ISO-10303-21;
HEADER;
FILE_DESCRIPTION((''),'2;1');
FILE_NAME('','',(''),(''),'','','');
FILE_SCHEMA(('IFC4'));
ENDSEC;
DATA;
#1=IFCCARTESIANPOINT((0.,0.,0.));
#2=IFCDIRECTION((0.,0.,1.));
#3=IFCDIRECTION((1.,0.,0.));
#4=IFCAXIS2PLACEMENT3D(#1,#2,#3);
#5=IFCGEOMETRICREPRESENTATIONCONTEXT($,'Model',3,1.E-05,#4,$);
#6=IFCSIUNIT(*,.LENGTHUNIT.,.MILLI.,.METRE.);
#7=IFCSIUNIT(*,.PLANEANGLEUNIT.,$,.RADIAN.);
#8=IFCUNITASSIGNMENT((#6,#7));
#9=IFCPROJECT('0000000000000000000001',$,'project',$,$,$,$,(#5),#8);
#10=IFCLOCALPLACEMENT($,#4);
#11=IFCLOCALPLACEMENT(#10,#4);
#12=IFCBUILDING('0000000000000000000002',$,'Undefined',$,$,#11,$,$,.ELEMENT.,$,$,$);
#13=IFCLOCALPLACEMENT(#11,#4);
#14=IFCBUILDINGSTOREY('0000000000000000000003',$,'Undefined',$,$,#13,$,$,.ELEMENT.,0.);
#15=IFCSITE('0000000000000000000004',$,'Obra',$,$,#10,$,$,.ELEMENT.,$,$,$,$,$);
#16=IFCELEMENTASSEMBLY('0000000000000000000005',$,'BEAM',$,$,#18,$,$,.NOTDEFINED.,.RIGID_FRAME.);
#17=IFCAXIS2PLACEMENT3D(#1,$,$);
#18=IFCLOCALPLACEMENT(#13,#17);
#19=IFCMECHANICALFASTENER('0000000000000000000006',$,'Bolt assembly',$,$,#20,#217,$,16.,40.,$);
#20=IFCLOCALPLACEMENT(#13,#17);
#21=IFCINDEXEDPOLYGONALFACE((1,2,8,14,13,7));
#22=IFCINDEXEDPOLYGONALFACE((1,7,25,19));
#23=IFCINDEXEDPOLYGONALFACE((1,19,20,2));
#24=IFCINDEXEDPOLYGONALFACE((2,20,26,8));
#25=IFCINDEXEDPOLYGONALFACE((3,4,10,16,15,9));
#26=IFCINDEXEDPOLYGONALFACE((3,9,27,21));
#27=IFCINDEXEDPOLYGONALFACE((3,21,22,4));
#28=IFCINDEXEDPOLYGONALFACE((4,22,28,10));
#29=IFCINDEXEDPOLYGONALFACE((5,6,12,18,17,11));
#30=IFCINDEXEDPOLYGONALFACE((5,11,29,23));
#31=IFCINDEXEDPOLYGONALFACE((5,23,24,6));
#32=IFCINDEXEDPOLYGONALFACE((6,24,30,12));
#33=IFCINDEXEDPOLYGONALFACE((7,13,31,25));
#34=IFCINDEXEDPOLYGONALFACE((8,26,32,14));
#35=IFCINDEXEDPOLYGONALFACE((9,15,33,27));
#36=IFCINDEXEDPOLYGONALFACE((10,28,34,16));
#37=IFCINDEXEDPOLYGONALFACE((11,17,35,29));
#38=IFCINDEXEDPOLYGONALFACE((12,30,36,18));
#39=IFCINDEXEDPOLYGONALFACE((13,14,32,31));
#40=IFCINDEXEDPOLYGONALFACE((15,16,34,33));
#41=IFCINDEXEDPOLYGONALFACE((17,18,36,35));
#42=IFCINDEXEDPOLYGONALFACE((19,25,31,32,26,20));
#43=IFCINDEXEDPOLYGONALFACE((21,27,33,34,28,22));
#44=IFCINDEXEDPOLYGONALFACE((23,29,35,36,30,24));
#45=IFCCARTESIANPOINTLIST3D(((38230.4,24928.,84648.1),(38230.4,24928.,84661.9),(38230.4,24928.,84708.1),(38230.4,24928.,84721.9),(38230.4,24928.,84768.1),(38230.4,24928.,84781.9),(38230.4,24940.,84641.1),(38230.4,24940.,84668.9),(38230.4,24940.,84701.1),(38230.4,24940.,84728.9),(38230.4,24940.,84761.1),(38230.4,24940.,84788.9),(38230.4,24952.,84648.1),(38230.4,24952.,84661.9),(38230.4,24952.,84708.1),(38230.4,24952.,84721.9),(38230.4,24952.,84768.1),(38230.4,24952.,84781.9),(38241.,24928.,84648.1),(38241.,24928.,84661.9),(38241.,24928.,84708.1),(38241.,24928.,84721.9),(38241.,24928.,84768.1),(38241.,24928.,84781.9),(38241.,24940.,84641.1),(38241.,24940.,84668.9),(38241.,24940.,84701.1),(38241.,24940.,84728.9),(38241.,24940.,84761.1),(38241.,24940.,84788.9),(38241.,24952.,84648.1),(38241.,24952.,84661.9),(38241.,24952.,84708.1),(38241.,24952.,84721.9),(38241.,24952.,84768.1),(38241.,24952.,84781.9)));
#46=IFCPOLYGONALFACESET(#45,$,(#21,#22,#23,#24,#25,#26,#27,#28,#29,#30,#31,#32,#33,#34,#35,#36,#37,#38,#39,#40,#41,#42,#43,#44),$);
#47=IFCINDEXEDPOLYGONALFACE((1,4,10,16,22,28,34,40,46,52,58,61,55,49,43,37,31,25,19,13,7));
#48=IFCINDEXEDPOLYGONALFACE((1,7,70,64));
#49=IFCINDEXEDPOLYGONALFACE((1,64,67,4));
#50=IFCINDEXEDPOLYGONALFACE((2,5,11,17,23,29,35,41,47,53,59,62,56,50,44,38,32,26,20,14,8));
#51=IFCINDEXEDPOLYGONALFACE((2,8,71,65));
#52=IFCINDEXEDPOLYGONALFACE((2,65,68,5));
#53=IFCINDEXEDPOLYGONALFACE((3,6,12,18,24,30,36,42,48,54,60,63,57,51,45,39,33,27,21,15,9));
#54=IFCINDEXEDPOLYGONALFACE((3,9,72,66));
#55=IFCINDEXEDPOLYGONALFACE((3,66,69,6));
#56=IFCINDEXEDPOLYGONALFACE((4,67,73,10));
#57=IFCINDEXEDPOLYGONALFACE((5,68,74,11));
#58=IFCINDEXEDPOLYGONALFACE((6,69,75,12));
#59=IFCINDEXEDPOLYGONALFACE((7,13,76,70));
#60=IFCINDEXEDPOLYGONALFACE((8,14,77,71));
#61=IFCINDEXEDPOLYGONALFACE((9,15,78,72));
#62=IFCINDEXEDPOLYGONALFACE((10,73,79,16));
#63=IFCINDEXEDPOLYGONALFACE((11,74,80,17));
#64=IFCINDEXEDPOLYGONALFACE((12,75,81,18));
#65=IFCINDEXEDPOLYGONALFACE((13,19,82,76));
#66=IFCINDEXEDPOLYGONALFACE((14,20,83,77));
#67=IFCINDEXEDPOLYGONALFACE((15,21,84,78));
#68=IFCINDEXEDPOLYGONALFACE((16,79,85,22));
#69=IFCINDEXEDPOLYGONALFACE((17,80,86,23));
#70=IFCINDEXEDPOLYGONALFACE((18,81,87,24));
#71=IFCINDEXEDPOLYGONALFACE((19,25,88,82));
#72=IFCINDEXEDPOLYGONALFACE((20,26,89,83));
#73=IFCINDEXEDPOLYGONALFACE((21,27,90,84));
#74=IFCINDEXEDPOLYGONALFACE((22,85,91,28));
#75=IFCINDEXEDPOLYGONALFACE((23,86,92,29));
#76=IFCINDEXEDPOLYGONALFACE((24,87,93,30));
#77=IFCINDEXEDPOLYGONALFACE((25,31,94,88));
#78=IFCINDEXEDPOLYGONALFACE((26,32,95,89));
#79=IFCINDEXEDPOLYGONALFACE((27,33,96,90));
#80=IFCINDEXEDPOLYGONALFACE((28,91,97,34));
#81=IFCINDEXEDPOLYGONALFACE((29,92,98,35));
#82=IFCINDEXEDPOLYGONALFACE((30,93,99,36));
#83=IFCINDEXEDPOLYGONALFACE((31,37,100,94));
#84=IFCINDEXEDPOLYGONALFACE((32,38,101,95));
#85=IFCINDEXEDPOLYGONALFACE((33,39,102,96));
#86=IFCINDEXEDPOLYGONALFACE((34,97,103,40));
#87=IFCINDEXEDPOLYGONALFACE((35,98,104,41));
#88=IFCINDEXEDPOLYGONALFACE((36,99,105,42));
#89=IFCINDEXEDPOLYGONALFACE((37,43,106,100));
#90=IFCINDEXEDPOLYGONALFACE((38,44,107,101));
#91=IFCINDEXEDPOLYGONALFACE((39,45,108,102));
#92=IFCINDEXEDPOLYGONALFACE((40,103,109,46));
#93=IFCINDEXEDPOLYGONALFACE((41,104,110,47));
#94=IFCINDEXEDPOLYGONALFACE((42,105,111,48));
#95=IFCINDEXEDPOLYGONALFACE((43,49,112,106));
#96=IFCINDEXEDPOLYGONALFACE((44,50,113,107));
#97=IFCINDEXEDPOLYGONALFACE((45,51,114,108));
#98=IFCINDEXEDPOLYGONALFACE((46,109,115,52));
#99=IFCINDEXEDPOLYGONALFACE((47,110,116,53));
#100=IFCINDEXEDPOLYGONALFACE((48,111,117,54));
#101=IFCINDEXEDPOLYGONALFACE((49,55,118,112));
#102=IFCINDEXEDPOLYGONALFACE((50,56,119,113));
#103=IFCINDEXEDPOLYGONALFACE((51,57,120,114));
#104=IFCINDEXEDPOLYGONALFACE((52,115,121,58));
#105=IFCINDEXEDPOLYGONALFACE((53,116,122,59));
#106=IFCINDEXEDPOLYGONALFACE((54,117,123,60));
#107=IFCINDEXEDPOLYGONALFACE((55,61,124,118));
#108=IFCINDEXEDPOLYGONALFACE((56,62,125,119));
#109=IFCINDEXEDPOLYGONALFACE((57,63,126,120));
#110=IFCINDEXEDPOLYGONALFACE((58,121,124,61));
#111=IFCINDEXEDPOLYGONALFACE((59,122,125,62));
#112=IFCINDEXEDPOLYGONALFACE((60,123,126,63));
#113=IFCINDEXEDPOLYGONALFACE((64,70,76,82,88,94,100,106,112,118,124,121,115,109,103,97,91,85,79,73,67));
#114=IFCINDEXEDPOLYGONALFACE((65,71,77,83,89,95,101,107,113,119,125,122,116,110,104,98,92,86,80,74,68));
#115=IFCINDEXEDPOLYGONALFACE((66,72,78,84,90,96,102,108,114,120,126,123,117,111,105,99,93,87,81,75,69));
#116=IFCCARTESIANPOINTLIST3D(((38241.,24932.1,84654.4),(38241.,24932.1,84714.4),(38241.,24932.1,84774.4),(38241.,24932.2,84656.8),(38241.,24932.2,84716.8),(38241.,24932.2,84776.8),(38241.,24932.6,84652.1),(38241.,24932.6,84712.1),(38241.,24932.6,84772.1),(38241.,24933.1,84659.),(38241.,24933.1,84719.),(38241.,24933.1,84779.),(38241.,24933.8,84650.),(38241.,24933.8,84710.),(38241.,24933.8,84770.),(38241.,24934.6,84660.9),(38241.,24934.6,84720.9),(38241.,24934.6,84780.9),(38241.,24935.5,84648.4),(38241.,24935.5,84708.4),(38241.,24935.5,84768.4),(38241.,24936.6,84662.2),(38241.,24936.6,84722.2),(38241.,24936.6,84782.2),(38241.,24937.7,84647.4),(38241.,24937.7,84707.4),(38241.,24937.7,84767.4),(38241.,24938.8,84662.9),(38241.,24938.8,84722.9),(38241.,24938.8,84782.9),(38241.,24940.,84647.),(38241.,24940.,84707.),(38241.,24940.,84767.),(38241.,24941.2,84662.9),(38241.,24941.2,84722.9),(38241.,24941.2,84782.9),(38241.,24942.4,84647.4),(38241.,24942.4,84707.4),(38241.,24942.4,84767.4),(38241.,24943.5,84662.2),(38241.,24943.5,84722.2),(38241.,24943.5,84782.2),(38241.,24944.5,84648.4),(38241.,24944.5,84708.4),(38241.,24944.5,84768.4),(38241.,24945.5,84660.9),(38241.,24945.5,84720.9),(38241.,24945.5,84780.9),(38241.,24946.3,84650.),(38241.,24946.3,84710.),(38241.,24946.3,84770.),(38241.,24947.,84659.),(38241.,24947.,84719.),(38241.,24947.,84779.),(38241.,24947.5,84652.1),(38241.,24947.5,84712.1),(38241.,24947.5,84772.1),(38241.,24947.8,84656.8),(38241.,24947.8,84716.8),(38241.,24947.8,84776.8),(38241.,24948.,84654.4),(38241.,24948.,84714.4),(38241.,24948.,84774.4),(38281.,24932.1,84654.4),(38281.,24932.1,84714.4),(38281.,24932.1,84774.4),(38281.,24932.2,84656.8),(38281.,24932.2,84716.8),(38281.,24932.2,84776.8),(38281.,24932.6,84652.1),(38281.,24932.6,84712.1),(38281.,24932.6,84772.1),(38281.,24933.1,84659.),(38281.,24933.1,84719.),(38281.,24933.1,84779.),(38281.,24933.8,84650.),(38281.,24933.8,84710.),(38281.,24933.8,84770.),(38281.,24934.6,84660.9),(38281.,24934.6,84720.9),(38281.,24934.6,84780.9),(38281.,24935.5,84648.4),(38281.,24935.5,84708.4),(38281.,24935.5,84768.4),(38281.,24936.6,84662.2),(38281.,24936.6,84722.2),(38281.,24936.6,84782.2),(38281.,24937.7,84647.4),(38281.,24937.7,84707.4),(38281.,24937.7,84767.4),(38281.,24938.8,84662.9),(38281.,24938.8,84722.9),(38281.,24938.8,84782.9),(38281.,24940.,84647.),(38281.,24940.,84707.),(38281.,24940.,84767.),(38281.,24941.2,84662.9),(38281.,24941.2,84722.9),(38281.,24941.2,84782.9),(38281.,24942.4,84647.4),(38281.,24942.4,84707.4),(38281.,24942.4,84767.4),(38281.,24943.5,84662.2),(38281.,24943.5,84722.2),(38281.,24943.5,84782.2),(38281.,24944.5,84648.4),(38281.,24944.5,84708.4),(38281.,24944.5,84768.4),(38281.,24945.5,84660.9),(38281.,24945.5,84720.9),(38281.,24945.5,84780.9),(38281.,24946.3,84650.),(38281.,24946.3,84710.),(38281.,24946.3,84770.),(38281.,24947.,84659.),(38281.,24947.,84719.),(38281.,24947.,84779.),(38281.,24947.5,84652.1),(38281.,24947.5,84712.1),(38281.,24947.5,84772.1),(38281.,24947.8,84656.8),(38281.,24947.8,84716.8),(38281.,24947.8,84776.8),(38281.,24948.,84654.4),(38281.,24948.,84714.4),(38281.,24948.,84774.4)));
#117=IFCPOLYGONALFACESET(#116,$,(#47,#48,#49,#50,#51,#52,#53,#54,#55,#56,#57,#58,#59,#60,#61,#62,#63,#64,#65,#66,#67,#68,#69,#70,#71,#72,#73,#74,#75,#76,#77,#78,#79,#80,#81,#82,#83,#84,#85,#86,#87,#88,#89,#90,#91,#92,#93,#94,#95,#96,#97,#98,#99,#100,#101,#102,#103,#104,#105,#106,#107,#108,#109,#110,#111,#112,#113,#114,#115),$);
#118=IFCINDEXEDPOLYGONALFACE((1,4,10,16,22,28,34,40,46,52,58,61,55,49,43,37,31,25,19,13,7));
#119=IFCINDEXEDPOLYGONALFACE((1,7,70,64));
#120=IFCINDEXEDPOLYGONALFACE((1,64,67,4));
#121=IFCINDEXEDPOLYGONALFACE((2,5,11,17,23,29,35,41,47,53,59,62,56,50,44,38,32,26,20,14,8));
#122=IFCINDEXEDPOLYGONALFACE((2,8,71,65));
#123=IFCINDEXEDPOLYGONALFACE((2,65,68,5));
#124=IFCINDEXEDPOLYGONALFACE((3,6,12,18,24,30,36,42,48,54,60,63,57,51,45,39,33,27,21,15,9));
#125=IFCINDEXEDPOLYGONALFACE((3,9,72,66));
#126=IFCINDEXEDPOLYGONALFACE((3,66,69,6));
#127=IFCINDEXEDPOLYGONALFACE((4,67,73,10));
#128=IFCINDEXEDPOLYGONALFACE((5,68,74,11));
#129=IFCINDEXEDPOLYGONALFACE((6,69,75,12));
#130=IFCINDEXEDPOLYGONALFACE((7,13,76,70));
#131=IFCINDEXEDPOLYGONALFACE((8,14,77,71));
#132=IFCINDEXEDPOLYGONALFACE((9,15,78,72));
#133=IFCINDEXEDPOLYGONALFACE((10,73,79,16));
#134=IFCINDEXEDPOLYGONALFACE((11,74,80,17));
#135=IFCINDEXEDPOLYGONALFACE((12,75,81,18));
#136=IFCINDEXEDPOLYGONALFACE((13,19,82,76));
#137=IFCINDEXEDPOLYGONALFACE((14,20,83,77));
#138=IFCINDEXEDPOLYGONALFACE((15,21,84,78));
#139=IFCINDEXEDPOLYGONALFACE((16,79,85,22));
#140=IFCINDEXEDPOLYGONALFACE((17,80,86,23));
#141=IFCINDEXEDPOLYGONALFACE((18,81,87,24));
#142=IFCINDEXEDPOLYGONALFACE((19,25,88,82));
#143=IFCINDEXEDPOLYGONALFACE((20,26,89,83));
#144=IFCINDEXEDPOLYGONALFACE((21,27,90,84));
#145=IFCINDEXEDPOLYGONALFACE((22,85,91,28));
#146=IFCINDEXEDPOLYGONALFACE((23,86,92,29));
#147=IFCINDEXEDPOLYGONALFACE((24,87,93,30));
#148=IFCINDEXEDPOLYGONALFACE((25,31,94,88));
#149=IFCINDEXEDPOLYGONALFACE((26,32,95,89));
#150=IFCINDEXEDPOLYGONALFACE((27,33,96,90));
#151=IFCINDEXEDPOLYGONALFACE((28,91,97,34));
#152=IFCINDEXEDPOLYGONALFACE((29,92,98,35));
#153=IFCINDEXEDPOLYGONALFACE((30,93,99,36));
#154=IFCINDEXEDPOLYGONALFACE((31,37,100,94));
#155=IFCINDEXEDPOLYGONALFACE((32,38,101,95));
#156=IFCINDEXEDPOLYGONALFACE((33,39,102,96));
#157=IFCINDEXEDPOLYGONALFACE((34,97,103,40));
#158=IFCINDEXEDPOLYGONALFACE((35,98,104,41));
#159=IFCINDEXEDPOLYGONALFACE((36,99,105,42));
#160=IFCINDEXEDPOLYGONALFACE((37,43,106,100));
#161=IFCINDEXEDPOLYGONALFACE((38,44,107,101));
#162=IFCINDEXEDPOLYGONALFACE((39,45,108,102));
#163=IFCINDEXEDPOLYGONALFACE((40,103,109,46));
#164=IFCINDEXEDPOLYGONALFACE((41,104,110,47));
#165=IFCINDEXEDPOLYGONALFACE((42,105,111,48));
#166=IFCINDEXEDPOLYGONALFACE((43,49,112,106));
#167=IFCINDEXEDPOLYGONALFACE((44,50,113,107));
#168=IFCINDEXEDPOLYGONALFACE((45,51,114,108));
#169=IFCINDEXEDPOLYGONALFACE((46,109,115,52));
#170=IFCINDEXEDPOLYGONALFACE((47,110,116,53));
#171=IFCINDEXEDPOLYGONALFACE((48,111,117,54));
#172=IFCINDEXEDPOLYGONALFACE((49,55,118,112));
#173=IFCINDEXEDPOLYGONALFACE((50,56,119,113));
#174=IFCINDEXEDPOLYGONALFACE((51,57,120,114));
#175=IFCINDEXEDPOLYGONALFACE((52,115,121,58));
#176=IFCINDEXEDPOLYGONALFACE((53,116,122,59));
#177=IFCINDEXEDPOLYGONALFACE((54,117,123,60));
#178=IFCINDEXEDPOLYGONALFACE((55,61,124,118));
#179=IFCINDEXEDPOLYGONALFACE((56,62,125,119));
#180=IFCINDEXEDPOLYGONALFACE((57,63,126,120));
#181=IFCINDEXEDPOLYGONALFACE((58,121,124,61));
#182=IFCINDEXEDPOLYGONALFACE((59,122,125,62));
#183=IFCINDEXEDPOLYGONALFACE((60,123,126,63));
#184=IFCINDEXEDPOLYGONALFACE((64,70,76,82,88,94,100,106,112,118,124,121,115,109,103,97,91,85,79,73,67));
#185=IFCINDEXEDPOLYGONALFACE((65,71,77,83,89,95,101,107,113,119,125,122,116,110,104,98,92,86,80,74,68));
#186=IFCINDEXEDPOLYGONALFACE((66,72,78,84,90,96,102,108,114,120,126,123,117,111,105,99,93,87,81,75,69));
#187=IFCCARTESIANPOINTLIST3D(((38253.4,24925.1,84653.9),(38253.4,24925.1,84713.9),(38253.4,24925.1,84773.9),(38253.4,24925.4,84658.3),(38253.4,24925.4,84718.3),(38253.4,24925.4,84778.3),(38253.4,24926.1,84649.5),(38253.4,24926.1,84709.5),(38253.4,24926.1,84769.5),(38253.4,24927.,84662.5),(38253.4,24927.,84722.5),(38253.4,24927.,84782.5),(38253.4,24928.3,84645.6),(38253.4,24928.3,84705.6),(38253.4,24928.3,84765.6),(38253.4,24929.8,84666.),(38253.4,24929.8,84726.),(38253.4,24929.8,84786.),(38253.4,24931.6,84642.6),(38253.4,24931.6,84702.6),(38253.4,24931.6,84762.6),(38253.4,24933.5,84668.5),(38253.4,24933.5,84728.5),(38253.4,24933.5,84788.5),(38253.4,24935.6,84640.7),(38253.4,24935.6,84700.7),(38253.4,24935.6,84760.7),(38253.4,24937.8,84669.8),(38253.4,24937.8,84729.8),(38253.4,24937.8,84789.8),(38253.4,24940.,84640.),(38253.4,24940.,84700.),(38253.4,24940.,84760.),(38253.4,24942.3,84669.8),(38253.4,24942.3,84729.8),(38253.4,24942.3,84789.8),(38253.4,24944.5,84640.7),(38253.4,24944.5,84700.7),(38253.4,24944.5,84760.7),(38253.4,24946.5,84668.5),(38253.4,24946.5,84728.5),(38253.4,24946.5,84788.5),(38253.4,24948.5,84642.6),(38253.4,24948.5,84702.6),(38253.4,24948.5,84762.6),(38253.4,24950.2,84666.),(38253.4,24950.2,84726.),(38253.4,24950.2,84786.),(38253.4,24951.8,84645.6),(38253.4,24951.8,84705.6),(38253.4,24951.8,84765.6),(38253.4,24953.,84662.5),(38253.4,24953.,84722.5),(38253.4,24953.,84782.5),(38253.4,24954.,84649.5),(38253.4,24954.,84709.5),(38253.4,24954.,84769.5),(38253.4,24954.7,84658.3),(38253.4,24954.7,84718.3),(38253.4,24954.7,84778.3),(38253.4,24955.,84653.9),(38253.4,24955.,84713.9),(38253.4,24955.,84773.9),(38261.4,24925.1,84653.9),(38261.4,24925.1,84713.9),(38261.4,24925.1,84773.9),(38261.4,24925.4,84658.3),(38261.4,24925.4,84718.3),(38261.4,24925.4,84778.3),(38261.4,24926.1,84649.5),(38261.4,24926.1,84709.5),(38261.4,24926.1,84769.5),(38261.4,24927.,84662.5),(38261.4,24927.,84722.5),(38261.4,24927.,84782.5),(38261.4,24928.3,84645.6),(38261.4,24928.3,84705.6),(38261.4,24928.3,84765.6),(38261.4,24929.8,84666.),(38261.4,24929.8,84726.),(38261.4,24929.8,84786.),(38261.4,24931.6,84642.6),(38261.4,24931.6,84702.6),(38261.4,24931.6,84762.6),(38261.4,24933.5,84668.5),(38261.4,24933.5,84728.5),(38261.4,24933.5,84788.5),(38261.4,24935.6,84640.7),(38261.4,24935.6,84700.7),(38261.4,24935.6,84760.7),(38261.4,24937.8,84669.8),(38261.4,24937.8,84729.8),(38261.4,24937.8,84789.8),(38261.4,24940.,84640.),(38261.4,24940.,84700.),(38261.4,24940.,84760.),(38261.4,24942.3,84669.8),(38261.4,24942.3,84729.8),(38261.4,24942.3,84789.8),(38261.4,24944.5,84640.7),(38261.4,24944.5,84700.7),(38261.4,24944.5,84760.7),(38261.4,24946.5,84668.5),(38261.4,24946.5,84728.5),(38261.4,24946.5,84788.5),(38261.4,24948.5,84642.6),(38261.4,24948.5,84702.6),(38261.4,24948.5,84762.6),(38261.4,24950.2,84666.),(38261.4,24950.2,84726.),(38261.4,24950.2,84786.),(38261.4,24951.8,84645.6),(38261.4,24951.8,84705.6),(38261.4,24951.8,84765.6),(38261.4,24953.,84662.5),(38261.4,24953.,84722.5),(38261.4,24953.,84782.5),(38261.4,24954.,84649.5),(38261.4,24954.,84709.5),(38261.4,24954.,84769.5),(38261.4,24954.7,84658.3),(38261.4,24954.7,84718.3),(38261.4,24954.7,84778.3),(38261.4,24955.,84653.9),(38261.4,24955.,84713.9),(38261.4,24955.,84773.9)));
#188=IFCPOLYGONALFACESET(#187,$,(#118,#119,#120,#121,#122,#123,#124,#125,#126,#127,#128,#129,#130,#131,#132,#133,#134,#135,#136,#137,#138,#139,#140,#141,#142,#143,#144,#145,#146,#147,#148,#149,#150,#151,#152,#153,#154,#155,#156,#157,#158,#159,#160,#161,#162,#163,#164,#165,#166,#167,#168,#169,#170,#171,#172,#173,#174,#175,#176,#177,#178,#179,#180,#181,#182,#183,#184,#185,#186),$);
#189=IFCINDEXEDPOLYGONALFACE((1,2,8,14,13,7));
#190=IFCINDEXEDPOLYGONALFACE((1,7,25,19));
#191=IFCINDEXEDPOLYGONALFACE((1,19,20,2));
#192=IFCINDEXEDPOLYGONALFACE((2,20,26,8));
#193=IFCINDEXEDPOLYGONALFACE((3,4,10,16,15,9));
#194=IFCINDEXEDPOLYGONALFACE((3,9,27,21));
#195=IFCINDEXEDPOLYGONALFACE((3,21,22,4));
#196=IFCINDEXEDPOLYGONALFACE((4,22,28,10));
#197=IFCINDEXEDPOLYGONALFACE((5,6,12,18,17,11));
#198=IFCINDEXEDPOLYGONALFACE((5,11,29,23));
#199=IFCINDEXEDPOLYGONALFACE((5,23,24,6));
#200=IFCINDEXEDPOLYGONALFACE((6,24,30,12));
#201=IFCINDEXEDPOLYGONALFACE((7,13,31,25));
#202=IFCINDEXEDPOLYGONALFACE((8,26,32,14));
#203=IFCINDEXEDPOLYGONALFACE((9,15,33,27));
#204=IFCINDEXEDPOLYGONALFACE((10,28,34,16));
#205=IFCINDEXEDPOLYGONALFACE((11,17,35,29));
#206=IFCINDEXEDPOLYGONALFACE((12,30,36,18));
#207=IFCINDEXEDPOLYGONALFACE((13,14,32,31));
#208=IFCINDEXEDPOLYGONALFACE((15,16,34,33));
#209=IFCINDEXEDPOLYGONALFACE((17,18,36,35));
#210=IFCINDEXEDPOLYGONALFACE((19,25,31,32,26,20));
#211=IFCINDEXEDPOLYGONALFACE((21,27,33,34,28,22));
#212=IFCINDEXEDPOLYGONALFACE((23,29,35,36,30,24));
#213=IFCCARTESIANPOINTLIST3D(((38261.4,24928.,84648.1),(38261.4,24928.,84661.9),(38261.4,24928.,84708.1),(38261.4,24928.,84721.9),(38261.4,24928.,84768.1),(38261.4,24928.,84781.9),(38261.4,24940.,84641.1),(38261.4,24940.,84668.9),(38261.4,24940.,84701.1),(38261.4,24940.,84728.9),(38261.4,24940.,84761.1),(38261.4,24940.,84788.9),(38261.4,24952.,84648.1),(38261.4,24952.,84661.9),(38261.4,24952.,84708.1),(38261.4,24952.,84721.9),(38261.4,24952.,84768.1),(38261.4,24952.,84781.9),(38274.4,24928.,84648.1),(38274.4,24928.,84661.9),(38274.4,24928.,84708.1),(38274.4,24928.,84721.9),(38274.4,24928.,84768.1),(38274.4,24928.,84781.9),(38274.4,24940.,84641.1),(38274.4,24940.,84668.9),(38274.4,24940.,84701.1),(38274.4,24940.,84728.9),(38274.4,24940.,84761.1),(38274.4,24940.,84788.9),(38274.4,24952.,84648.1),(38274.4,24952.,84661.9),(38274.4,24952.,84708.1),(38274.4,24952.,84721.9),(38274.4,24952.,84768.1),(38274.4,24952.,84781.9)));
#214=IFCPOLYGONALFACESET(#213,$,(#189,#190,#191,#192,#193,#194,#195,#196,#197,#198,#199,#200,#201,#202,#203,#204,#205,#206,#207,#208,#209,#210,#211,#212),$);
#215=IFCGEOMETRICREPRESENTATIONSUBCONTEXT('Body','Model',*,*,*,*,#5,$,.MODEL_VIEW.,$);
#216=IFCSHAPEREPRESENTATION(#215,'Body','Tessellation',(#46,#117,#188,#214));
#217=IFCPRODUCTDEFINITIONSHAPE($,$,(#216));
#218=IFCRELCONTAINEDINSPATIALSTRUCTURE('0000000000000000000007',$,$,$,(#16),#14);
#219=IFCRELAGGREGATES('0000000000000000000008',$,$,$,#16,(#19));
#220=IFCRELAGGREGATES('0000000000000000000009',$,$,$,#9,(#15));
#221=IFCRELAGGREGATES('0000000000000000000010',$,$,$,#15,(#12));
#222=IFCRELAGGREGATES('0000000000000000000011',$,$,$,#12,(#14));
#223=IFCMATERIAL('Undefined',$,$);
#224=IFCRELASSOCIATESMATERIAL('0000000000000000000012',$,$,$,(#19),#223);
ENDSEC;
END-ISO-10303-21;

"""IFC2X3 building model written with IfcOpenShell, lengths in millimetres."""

from ifc_helpers import new_model, si_unit, frame, origin_with_axes, origin_2d_with_axis, place, context, subcontext, project, spatial, polyline, circle, outline, extrude, source, transform, mapped, material, element, aggregate, save


model = new_model("IFC2X3")

# Units and contexts
model_context = context("Model", 3, precision=1e-05, world=origin_with_axes())
body_context = subcontext(model_context, "Body", "Model", "MODEL_VIEW")
ifc_project = project(units=[si_unit("LENGTHUNIT", "METRE", prefix="MILLI"), si_unit("PLANEANGLEUNIT", "RADIAN")], contexts=[model_context])

# Site, building, storey
site_placement = place(None, origin_with_axes())
site = spatial("IfcSite", under=ifc_project, at=site_placement, Name="Obra", CompositionType="ELEMENT")
building_placement = place(site_placement, origin_with_axes())
building = spatial("IfcBuilding", under=site, at=building_placement, Name="Undefined", CompositionType="ELEMENT")
storey_placement = place(building_placement, origin_with_axes())
storey = spatial("IfcBuildingStorey", under=building, at=storey_placement, Name="Undefined", CompositionType="ELEMENT", Elevation=0.0)

# Shared definitions
ifc_material_1 = material(Name="Undefined")

# Element assembly, mechanical fastener
assembly_1_placement = place(storey_placement, origin_with_axes())
assembly_1 = element("IfcElementAssembly", 1, at=assembly_1_placement, inside=storey, Name="BEAM", AssemblyPlace="NOTDEFINED", PredefinedType="RIGID_FRAME")
shared_shape_1 = source(origin_with_axes(), body_context, "Body", "SweptSolid", [
    extrude(outline(polyline([(13.9, 0.0), (6.9, 12.0), (-6.9, 12.0), (-13.9, 0.0), (-6.9, -12.0), (6.9, -12.0), (13.9, 0.0)])), frame((0.0, -19.7, 0.0), z_axis=(0.0, 1.0, 0.0), x_axis=(1.0, 0.0, 0.0)), (0.0, 0.0, 1.0), 10.6),
    extrude(circle(Radius=8.0, at=origin_2d_with_axis()), frame((0.0, -9.1, 0.0), z_axis=(0.0, 1.0, 0.0), x_axis=(1.0, 0.0, 0.0)), (0.0, 0.0, 1.0), 40.0),
    extrude(circle(Radius=15.0, at=origin_2d_with_axis()), frame((0.0, 3.3, 0.0), z_axis=(0.0, 1.0, 0.0), x_axis=(1.0, 0.0, 0.0)), (0.0, 0.0, 1.0), 8.0),
    extrude(outline(polyline([(13.9, 0.0), (6.9, 12.0), (-6.9, 12.0), (-13.9, 0.0), (-6.9, -12.0), (6.9, -12.0), (13.9, 0.0)])), frame((0.0, 11.3, 0.0), z_axis=(0.0, 1.0, 0.0), x_axis=(1.0, 0.0, 0.0)), (0.0, 0.0, 1.0), 13.0),
])
mechanical_fastener_1_placement = place(assembly_1_placement, frame((38250.1, 24990.0, 84835.0), z_axis=(0.000002, -1.0, 0.0), x_axis=(0.0, 0.0, -1.0)))
mechanical_fastener_1 = element("IfcMechanicalFastener", 2, at=mechanical_fastener_1_placement, material=ifc_material_1, Name="Bolt assembly", NominalDiameter=16.0, NominalLength=40.0, context=body_context, shape_type="MappedRepresentation", body=[
    mapped(shared_shape_1, transform((60.0, 0.0, 50.0))),
    mapped(shared_shape_1, transform((120.0, 0.0, 50.0))),
    mapped(shared_shape_1, transform((180.0, 0.0, 50.0))),
])
aggregate(assembly_1, [mechanical_fastener_1])

save(model, "model.ifc")
